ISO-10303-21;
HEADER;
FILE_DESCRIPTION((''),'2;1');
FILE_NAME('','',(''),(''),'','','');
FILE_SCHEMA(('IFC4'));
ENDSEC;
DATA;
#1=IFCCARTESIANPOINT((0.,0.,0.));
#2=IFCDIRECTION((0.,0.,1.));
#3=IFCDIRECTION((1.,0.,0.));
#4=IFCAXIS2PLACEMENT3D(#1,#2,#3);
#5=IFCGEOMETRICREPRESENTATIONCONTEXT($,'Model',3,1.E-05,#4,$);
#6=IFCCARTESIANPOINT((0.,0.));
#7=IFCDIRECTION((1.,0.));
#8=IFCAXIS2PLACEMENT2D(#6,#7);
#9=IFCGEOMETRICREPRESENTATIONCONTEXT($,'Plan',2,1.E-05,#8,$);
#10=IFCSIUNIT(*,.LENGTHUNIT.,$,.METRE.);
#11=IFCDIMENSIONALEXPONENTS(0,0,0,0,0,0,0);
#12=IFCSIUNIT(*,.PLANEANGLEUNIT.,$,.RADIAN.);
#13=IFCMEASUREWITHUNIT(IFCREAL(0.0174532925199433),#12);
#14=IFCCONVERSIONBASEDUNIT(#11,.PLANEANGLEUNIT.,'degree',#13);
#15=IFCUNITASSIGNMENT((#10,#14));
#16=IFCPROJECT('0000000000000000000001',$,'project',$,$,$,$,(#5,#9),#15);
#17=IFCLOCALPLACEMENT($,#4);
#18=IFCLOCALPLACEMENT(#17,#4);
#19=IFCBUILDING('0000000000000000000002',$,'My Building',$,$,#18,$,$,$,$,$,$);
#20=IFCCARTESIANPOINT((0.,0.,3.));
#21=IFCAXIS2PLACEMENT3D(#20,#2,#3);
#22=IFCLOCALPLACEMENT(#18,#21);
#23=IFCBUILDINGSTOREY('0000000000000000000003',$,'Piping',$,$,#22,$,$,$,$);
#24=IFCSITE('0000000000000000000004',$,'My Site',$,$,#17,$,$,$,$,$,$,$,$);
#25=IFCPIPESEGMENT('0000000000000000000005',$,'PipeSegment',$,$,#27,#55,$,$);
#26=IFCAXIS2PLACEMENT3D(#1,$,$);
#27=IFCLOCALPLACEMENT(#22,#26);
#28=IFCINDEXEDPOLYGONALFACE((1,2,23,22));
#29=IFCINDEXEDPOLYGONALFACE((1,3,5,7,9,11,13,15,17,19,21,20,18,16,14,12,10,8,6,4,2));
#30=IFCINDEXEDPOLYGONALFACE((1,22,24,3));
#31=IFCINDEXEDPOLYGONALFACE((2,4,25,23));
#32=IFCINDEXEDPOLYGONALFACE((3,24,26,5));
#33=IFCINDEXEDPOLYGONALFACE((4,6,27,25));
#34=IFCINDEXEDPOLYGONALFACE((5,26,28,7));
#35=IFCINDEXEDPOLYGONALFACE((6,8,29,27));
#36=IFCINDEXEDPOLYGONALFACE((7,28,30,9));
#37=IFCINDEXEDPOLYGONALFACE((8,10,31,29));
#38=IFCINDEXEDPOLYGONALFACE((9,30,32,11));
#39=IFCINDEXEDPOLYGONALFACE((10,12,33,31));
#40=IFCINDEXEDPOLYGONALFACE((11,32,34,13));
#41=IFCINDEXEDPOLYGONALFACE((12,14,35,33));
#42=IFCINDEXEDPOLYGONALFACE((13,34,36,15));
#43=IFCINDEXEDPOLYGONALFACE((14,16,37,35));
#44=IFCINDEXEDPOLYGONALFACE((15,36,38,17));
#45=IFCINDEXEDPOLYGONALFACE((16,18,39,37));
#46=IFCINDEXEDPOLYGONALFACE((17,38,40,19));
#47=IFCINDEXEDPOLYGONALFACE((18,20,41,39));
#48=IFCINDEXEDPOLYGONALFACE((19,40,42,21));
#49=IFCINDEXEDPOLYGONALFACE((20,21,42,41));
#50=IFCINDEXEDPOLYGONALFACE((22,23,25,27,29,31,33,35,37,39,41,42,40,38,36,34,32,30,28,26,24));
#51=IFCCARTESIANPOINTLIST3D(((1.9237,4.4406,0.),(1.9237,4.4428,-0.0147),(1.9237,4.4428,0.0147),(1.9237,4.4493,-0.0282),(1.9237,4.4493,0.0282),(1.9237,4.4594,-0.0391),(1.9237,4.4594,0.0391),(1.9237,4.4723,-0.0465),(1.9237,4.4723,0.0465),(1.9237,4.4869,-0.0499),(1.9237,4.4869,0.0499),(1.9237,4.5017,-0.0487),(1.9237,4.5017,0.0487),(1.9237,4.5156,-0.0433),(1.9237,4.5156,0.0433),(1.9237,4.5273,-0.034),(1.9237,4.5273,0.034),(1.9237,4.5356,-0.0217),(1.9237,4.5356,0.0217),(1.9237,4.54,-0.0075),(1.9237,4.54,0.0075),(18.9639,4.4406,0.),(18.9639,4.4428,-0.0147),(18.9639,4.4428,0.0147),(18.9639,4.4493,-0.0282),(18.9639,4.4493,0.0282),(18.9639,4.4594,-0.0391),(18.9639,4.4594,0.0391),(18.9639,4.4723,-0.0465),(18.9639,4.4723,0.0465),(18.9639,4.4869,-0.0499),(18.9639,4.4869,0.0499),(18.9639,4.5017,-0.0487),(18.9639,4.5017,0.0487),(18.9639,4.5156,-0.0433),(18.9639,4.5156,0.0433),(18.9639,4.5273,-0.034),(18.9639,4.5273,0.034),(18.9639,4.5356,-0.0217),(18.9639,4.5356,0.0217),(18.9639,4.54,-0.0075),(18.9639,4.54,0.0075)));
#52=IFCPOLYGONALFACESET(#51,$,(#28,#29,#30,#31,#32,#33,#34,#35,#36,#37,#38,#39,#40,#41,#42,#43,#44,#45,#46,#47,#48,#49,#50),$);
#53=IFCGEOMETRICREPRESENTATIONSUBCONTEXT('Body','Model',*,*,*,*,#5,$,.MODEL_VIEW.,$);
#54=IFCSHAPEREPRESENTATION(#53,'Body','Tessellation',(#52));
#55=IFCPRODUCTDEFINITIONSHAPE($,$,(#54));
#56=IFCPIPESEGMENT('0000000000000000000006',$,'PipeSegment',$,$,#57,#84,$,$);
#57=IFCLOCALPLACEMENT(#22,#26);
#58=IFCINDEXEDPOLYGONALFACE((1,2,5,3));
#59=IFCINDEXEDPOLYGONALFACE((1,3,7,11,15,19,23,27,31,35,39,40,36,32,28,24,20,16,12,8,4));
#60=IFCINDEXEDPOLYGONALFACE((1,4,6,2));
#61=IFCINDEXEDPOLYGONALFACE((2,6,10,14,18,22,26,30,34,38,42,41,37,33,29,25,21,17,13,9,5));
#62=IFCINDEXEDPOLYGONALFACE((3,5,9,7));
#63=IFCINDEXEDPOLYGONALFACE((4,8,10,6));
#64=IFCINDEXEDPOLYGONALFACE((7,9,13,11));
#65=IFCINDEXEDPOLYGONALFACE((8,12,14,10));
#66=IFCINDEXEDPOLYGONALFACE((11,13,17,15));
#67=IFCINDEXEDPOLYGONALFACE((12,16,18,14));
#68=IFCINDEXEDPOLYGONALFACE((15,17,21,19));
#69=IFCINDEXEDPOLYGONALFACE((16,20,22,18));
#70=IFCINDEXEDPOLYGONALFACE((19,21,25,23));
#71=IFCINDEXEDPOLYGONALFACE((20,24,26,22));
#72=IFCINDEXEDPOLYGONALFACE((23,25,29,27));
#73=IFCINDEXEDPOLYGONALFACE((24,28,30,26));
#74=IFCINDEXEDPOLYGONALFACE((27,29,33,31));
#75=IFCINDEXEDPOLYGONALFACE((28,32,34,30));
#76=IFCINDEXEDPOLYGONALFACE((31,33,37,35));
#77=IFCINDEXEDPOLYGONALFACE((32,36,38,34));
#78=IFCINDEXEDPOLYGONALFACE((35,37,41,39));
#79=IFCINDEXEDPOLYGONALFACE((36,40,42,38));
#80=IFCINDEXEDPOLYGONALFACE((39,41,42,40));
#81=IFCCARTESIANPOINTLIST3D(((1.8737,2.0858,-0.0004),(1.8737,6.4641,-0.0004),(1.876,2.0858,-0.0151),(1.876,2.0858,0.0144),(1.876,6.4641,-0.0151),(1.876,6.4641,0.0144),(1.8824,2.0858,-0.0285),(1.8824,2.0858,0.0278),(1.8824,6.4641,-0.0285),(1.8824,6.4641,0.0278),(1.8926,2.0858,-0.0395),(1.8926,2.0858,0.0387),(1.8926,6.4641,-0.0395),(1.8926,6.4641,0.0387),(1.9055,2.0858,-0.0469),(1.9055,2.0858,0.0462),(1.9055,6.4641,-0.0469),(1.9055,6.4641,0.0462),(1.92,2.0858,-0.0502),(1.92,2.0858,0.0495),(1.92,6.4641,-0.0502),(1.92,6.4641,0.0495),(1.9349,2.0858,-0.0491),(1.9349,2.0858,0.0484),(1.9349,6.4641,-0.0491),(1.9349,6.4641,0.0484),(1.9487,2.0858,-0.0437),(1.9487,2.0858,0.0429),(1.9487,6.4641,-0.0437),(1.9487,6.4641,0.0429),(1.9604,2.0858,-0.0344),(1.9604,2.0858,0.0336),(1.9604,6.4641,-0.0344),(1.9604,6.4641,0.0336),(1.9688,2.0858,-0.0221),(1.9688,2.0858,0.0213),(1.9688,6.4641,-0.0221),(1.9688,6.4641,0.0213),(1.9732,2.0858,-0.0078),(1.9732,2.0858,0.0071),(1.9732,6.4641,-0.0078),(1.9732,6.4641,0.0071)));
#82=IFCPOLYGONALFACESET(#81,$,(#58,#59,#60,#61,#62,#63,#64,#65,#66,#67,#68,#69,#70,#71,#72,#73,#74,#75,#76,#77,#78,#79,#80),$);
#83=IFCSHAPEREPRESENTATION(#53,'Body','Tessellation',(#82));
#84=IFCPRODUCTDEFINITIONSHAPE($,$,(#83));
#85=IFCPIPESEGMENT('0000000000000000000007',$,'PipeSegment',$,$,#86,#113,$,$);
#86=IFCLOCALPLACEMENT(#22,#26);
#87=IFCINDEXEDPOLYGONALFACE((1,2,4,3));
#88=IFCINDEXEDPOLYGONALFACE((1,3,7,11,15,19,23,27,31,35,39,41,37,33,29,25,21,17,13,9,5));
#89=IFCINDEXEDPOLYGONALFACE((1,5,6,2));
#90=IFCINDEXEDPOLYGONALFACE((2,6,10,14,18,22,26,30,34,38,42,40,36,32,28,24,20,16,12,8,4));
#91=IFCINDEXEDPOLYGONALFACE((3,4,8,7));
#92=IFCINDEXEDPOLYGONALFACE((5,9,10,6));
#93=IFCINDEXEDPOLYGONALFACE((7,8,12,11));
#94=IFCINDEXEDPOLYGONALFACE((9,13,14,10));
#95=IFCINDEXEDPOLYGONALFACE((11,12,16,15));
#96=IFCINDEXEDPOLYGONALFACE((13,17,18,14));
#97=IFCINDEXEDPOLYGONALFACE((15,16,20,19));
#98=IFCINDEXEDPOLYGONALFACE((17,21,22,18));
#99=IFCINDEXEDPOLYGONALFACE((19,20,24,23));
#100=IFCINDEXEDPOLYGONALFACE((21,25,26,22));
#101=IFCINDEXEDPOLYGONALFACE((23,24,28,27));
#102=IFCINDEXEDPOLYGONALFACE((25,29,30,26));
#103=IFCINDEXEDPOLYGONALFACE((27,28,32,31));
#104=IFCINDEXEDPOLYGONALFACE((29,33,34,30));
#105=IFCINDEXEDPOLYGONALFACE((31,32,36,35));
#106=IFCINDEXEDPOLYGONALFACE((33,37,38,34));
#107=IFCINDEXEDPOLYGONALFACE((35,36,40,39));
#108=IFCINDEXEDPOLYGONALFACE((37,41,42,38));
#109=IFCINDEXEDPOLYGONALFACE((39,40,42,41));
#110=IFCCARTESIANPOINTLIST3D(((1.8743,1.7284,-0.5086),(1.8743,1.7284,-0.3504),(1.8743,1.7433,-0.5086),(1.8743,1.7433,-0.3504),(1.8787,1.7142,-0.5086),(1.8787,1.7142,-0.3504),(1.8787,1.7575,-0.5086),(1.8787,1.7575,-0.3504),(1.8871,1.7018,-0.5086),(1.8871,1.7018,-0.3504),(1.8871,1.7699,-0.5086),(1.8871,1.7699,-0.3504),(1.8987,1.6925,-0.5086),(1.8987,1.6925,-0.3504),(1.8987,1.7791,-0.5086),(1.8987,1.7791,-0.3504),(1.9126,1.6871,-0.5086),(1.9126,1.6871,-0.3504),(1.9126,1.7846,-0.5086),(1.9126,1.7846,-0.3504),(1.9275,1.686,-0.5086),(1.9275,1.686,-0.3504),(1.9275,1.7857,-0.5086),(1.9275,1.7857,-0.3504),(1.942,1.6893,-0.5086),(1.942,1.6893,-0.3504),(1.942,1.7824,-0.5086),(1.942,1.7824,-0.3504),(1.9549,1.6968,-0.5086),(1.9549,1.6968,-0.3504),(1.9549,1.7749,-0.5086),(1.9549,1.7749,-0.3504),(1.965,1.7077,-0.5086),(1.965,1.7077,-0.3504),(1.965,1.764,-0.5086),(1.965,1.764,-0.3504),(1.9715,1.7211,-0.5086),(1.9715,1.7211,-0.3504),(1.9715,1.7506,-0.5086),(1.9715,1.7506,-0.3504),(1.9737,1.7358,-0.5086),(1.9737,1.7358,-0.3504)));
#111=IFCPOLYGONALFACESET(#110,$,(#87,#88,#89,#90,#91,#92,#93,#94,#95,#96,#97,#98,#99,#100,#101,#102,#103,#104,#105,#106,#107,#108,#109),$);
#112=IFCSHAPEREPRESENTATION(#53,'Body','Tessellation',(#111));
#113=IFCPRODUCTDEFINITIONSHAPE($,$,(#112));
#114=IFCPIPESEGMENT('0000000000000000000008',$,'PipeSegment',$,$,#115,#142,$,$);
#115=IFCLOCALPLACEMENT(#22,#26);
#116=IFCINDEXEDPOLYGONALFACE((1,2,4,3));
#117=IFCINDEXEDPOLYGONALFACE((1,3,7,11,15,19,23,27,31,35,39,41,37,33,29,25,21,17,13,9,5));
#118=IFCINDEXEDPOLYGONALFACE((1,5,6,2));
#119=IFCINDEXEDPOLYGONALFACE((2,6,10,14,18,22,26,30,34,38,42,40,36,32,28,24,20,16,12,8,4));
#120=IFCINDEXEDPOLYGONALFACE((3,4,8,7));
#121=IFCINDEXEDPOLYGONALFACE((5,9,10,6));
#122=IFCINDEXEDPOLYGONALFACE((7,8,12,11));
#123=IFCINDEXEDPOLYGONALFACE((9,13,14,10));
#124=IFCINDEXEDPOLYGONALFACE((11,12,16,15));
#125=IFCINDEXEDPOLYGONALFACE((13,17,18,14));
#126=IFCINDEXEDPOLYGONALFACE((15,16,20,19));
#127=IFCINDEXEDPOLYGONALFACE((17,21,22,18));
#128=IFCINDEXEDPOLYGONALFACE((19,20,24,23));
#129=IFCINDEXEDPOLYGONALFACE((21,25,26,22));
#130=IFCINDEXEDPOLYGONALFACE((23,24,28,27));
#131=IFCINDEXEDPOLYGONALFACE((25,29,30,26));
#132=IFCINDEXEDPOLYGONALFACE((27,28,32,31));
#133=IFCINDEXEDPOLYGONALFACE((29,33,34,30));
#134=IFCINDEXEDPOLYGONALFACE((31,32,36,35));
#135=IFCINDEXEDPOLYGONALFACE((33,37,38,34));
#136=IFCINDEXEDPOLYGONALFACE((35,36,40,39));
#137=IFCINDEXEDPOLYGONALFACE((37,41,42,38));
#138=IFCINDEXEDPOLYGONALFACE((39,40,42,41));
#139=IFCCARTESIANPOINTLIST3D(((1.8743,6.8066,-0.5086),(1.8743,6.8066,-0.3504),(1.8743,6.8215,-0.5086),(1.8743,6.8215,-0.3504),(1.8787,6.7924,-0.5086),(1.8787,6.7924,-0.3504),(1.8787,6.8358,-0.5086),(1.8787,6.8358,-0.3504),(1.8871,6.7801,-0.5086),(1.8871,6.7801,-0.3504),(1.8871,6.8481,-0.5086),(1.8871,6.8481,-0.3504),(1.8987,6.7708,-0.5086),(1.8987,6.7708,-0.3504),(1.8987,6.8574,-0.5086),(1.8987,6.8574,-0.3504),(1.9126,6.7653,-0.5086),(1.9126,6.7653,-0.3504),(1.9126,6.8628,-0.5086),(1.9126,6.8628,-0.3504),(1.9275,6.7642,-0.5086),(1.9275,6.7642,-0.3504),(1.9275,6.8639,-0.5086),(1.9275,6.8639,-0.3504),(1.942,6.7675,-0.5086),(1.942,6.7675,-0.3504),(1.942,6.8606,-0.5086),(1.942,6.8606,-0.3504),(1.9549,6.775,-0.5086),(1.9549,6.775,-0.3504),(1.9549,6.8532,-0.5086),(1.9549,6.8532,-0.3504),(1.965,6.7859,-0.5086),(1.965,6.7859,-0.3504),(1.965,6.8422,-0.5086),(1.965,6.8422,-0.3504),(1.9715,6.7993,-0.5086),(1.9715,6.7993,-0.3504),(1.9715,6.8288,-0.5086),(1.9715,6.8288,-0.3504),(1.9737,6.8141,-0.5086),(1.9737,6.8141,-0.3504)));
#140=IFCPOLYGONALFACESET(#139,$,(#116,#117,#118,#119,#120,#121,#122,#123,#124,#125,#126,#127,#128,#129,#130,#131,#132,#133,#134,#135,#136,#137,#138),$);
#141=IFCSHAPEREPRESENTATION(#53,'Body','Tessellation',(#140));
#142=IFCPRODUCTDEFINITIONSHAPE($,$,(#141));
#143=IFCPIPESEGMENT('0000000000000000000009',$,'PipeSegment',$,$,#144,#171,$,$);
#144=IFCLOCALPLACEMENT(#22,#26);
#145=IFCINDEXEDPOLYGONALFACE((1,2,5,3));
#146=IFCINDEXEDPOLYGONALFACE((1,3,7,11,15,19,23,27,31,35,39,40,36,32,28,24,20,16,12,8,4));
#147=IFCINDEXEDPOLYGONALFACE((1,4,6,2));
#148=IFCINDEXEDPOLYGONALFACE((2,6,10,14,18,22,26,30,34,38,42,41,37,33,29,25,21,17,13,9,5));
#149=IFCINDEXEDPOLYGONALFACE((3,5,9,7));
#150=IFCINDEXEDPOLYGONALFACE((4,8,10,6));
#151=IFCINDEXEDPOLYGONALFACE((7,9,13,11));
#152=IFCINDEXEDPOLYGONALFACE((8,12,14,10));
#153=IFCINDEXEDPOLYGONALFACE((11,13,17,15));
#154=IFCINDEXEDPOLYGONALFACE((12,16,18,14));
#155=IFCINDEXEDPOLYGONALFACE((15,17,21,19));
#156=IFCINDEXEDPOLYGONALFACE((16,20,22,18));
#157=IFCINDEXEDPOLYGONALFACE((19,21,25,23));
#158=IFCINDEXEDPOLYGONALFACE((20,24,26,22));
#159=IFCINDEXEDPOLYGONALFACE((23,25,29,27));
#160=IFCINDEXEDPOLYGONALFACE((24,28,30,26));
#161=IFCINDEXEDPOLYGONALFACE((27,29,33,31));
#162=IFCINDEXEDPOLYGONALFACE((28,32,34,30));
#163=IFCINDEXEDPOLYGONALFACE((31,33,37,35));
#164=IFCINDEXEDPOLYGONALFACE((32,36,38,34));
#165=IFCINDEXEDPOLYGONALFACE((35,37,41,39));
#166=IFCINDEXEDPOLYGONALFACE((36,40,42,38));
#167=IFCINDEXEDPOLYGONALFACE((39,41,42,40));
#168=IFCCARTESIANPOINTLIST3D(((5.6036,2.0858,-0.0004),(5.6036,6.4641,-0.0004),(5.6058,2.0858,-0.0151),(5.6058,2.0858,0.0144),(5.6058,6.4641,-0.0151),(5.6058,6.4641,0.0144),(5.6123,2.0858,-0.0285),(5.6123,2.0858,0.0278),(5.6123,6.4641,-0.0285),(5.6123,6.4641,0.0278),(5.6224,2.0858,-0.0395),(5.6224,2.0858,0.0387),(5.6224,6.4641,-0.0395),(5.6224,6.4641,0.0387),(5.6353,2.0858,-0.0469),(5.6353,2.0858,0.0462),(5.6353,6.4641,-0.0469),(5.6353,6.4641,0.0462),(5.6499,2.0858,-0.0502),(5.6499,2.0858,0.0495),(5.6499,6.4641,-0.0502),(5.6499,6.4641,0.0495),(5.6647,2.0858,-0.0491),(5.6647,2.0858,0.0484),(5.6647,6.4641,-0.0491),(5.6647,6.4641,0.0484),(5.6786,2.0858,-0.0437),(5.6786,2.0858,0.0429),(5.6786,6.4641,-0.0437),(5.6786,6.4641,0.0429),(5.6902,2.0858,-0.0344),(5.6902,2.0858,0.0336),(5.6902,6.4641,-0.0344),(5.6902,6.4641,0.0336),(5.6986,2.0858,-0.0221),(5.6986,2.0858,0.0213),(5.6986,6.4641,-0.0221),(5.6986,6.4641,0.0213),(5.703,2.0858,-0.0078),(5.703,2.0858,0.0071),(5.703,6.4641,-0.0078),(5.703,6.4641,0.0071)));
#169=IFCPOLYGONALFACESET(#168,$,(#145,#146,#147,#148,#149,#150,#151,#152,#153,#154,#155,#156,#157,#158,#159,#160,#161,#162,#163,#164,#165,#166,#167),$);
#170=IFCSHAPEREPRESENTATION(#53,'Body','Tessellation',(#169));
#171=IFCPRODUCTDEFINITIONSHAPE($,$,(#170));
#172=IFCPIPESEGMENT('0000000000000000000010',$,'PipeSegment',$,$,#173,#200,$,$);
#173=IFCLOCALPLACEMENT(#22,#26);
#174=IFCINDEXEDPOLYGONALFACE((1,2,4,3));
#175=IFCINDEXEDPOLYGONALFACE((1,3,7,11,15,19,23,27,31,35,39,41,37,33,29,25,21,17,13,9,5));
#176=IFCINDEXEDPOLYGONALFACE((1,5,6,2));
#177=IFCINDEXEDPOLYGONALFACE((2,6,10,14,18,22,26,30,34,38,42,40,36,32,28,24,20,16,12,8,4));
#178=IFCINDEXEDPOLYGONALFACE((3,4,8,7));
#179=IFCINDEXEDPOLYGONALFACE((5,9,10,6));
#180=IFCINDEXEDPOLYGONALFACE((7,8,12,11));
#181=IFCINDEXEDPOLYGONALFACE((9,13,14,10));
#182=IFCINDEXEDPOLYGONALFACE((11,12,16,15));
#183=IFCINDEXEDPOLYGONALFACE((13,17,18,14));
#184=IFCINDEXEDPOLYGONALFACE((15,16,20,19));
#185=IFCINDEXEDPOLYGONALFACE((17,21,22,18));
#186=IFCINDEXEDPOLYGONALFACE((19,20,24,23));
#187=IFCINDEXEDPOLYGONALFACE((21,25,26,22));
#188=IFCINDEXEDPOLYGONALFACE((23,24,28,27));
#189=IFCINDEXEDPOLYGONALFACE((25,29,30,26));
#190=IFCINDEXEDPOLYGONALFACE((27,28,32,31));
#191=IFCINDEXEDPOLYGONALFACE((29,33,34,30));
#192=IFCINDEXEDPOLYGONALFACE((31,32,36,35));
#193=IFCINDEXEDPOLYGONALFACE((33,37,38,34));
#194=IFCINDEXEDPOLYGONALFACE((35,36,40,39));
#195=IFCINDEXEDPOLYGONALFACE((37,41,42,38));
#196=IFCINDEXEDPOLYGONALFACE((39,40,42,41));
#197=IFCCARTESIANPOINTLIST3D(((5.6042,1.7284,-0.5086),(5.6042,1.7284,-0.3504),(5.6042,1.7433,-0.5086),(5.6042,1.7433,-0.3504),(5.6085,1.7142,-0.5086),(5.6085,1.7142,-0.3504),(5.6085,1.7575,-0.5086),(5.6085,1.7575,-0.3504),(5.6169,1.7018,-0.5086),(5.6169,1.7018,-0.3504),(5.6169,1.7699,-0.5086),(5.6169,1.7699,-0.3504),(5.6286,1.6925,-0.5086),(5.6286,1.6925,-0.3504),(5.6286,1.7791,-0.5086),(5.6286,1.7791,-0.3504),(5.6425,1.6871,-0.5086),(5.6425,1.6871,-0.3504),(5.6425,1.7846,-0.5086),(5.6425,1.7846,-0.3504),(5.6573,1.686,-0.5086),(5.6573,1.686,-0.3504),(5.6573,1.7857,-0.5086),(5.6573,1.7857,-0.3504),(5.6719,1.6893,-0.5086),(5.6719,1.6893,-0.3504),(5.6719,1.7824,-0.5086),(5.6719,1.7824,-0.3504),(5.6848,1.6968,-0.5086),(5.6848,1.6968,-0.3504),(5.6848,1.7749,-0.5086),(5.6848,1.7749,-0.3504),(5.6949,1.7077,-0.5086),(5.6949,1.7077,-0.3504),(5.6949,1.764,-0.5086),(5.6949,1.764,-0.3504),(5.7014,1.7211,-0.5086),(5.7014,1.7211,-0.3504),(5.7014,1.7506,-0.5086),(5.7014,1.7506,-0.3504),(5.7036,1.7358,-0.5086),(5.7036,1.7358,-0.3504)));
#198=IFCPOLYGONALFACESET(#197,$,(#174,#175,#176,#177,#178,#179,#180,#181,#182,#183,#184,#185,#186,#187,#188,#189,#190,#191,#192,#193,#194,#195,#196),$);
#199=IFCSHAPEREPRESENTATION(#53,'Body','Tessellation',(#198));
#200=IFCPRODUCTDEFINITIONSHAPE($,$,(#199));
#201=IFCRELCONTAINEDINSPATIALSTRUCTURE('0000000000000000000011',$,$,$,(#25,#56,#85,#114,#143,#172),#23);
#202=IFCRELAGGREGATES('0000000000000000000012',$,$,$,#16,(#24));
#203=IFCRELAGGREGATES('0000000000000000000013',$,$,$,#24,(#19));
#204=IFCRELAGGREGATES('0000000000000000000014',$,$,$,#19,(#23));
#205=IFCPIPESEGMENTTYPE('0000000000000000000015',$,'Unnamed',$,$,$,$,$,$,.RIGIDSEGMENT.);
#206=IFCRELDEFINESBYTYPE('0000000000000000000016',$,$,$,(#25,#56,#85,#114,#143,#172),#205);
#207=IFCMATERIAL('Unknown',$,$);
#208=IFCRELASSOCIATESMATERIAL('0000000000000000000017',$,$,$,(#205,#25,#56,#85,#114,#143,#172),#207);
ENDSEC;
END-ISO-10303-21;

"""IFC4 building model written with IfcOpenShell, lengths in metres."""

from ifc_helpers import new_model, entity, si_unit, converted_unit, frame, origin_with_axes, origin_2d_with_axis, place, context, subcontext, project, spatial, circle, extrude, material, material_profile, profile_set, profile_usage, type_object, element, save


model = new_model("IFC4")

# Units and contexts
model_context = context("Model", 3, precision=1e-05, world=origin_with_axes())
plan_context = context("Plan", 2, precision=1e-05, world=origin_2d_with_axis())
body_context = subcontext(model_context, "Body", "Model", "MODEL_VIEW")
ifc_project = project(units=[si_unit("LENGTHUNIT", "METRE"), converted_unit("PLANEANGLEUNIT", "degree", entity("IfcReal", 0.0174532925199433), si_unit("PLANEANGLEUNIT", "RADIAN"), dimensions=[0, 0, 0, 0, 0, 0, 0])], contexts=[model_context, plan_context])

# Site, building, storey
site_placement = place(None, origin_with_axes())
site = spatial("IfcSite", under=ifc_project, at=site_placement, Name="My Site")
building_placement = place(site_placement, origin_with_axes())
building = spatial("IfcBuilding", under=site, at=building_placement, Name="My Building")
storey_placement = place(building_placement, frame((0.0, 0.0, 3.0), z_axis=(0.0, 0.0, 1.0), x_axis=(1.0, 0.0, 0.0)))
storey = spatial("IfcBuildingStorey", under=building, at=storey_placement, Name="Piping")

# Pipe segments
ifc_material = material(Name="Unknown")
ifc_material_profile = material_profile(ifc_material, circle(Radius=0.05))
ifc_profile_set = profile_set([ifc_material_profile])
ifc_profile_usage_1 = profile_usage(ifc_profile_set, cardinal=5)
pipe_segment_type = type_object("IfcPipeSegmentType", Name="Unnamed", PredefinedType="RIGIDSEGMENT", material=ifc_profile_set)
pipe_segment_1_placement = place(storey_placement, frame((18.9639, 4.4906, 0.0), z_axis=(-1.0, 0.0, 0.0), x_axis=(0.0, -1.0, 0.0)))
element("IfcPipeSegment", 1, at=pipe_segment_1_placement, inside=storey, type_object=pipe_segment_type, material=ifc_profile_usage_1, Name="PipeSegment", context=body_context, shape_type="SweptSolid", body=[
    extrude(circle(Radius=0.05), origin_with_axes(), (0.0, 0.0, 1.0), 17.0401),
])
ifc_profile_usage_2 = profile_usage(ifc_profile_set, cardinal=5)
pipe_segment_2_placement = place(storey_placement, frame((1.9237, 2.0858, -0.0004), z_axis=(0.0, 1.0, 0.0), x_axis=(-1.0, 0.0, 0.0)))
element("IfcPipeSegment", 2, at=pipe_segment_2_placement, inside=storey, type_object=pipe_segment_type, material=ifc_profile_usage_2, Name="PipeSegment", context=body_context, shape_type="SweptSolid", body=[
    extrude(circle(Radius=0.05), origin_with_axes(), (0.0, 0.0, 1.0), 4.3782),
])
ifc_profile_usage_3 = profile_usage(ifc_profile_set, cardinal=5)
pipe_segment_3_placement = place(storey_placement, frame((1.9237, 1.7358, -0.3504), z_axis=(0.0, 0.0, -1.0), x_axis=(1.0, 0.0, 0.0)))
element("IfcPipeSegment", 3, at=pipe_segment_3_placement, inside=storey, type_object=pipe_segment_type, material=ifc_profile_usage_3, Name="PipeSegment", context=body_context, shape_type="SweptSolid", body=[
    extrude(circle(Radius=0.05), origin_with_axes(), (0.0, 0.0, 1.0), 0.1582),
])
ifc_profile_usage_4 = profile_usage(ifc_profile_set, cardinal=5)
pipe_segment_4_placement = place(storey_placement, frame((1.9237, 6.8141, -0.3504), z_axis=(0.0, 0.0, -1.0), x_axis=(1.0, 0.0, 0.0)))
element("IfcPipeSegment", 4, at=pipe_segment_4_placement, inside=storey, type_object=pipe_segment_type, material=ifc_profile_usage_4, Name="PipeSegment", context=body_context, shape_type="SweptSolid", body=[
    extrude(circle(Radius=0.05), origin_with_axes(), (0.0, 0.0, 1.0), 0.1582),
])
ifc_profile_usage_5 = profile_usage(ifc_profile_set, cardinal=5)
pipe_segment_5_placement = place(storey_placement, frame((5.6536, 2.0858, -0.0004), z_axis=(0.0, 1.0, 0.0), x_axis=(-1.0, 0.0, 0.0)))
element("IfcPipeSegment", 5, at=pipe_segment_5_placement, inside=storey, type_object=pipe_segment_type, material=ifc_profile_usage_5, Name="PipeSegment", context=body_context, shape_type="SweptSolid", body=[
    extrude(circle(Radius=0.05), origin_with_axes(), (0.0, 0.0, 1.0), 4.3782),
])
ifc_profile_usage_6 = profile_usage(ifc_profile_set, cardinal=5)
pipe_segment_6_placement = place(storey_placement, frame((5.6536, 1.7358, -0.3504), z_axis=(0.0, 0.0, -1.0), x_axis=(1.0, 0.0, 0.0)))
element("IfcPipeSegment", 6, at=pipe_segment_6_placement, inside=storey, type_object=pipe_segment_type, material=ifc_profile_usage_6, Name="PipeSegment", context=body_context, shape_type="SweptSolid", body=[
    extrude(circle(Radius=0.05), origin_with_axes(), (0.0, 0.0, 1.0), 0.1582),
])

save(model, "model.ifc")
